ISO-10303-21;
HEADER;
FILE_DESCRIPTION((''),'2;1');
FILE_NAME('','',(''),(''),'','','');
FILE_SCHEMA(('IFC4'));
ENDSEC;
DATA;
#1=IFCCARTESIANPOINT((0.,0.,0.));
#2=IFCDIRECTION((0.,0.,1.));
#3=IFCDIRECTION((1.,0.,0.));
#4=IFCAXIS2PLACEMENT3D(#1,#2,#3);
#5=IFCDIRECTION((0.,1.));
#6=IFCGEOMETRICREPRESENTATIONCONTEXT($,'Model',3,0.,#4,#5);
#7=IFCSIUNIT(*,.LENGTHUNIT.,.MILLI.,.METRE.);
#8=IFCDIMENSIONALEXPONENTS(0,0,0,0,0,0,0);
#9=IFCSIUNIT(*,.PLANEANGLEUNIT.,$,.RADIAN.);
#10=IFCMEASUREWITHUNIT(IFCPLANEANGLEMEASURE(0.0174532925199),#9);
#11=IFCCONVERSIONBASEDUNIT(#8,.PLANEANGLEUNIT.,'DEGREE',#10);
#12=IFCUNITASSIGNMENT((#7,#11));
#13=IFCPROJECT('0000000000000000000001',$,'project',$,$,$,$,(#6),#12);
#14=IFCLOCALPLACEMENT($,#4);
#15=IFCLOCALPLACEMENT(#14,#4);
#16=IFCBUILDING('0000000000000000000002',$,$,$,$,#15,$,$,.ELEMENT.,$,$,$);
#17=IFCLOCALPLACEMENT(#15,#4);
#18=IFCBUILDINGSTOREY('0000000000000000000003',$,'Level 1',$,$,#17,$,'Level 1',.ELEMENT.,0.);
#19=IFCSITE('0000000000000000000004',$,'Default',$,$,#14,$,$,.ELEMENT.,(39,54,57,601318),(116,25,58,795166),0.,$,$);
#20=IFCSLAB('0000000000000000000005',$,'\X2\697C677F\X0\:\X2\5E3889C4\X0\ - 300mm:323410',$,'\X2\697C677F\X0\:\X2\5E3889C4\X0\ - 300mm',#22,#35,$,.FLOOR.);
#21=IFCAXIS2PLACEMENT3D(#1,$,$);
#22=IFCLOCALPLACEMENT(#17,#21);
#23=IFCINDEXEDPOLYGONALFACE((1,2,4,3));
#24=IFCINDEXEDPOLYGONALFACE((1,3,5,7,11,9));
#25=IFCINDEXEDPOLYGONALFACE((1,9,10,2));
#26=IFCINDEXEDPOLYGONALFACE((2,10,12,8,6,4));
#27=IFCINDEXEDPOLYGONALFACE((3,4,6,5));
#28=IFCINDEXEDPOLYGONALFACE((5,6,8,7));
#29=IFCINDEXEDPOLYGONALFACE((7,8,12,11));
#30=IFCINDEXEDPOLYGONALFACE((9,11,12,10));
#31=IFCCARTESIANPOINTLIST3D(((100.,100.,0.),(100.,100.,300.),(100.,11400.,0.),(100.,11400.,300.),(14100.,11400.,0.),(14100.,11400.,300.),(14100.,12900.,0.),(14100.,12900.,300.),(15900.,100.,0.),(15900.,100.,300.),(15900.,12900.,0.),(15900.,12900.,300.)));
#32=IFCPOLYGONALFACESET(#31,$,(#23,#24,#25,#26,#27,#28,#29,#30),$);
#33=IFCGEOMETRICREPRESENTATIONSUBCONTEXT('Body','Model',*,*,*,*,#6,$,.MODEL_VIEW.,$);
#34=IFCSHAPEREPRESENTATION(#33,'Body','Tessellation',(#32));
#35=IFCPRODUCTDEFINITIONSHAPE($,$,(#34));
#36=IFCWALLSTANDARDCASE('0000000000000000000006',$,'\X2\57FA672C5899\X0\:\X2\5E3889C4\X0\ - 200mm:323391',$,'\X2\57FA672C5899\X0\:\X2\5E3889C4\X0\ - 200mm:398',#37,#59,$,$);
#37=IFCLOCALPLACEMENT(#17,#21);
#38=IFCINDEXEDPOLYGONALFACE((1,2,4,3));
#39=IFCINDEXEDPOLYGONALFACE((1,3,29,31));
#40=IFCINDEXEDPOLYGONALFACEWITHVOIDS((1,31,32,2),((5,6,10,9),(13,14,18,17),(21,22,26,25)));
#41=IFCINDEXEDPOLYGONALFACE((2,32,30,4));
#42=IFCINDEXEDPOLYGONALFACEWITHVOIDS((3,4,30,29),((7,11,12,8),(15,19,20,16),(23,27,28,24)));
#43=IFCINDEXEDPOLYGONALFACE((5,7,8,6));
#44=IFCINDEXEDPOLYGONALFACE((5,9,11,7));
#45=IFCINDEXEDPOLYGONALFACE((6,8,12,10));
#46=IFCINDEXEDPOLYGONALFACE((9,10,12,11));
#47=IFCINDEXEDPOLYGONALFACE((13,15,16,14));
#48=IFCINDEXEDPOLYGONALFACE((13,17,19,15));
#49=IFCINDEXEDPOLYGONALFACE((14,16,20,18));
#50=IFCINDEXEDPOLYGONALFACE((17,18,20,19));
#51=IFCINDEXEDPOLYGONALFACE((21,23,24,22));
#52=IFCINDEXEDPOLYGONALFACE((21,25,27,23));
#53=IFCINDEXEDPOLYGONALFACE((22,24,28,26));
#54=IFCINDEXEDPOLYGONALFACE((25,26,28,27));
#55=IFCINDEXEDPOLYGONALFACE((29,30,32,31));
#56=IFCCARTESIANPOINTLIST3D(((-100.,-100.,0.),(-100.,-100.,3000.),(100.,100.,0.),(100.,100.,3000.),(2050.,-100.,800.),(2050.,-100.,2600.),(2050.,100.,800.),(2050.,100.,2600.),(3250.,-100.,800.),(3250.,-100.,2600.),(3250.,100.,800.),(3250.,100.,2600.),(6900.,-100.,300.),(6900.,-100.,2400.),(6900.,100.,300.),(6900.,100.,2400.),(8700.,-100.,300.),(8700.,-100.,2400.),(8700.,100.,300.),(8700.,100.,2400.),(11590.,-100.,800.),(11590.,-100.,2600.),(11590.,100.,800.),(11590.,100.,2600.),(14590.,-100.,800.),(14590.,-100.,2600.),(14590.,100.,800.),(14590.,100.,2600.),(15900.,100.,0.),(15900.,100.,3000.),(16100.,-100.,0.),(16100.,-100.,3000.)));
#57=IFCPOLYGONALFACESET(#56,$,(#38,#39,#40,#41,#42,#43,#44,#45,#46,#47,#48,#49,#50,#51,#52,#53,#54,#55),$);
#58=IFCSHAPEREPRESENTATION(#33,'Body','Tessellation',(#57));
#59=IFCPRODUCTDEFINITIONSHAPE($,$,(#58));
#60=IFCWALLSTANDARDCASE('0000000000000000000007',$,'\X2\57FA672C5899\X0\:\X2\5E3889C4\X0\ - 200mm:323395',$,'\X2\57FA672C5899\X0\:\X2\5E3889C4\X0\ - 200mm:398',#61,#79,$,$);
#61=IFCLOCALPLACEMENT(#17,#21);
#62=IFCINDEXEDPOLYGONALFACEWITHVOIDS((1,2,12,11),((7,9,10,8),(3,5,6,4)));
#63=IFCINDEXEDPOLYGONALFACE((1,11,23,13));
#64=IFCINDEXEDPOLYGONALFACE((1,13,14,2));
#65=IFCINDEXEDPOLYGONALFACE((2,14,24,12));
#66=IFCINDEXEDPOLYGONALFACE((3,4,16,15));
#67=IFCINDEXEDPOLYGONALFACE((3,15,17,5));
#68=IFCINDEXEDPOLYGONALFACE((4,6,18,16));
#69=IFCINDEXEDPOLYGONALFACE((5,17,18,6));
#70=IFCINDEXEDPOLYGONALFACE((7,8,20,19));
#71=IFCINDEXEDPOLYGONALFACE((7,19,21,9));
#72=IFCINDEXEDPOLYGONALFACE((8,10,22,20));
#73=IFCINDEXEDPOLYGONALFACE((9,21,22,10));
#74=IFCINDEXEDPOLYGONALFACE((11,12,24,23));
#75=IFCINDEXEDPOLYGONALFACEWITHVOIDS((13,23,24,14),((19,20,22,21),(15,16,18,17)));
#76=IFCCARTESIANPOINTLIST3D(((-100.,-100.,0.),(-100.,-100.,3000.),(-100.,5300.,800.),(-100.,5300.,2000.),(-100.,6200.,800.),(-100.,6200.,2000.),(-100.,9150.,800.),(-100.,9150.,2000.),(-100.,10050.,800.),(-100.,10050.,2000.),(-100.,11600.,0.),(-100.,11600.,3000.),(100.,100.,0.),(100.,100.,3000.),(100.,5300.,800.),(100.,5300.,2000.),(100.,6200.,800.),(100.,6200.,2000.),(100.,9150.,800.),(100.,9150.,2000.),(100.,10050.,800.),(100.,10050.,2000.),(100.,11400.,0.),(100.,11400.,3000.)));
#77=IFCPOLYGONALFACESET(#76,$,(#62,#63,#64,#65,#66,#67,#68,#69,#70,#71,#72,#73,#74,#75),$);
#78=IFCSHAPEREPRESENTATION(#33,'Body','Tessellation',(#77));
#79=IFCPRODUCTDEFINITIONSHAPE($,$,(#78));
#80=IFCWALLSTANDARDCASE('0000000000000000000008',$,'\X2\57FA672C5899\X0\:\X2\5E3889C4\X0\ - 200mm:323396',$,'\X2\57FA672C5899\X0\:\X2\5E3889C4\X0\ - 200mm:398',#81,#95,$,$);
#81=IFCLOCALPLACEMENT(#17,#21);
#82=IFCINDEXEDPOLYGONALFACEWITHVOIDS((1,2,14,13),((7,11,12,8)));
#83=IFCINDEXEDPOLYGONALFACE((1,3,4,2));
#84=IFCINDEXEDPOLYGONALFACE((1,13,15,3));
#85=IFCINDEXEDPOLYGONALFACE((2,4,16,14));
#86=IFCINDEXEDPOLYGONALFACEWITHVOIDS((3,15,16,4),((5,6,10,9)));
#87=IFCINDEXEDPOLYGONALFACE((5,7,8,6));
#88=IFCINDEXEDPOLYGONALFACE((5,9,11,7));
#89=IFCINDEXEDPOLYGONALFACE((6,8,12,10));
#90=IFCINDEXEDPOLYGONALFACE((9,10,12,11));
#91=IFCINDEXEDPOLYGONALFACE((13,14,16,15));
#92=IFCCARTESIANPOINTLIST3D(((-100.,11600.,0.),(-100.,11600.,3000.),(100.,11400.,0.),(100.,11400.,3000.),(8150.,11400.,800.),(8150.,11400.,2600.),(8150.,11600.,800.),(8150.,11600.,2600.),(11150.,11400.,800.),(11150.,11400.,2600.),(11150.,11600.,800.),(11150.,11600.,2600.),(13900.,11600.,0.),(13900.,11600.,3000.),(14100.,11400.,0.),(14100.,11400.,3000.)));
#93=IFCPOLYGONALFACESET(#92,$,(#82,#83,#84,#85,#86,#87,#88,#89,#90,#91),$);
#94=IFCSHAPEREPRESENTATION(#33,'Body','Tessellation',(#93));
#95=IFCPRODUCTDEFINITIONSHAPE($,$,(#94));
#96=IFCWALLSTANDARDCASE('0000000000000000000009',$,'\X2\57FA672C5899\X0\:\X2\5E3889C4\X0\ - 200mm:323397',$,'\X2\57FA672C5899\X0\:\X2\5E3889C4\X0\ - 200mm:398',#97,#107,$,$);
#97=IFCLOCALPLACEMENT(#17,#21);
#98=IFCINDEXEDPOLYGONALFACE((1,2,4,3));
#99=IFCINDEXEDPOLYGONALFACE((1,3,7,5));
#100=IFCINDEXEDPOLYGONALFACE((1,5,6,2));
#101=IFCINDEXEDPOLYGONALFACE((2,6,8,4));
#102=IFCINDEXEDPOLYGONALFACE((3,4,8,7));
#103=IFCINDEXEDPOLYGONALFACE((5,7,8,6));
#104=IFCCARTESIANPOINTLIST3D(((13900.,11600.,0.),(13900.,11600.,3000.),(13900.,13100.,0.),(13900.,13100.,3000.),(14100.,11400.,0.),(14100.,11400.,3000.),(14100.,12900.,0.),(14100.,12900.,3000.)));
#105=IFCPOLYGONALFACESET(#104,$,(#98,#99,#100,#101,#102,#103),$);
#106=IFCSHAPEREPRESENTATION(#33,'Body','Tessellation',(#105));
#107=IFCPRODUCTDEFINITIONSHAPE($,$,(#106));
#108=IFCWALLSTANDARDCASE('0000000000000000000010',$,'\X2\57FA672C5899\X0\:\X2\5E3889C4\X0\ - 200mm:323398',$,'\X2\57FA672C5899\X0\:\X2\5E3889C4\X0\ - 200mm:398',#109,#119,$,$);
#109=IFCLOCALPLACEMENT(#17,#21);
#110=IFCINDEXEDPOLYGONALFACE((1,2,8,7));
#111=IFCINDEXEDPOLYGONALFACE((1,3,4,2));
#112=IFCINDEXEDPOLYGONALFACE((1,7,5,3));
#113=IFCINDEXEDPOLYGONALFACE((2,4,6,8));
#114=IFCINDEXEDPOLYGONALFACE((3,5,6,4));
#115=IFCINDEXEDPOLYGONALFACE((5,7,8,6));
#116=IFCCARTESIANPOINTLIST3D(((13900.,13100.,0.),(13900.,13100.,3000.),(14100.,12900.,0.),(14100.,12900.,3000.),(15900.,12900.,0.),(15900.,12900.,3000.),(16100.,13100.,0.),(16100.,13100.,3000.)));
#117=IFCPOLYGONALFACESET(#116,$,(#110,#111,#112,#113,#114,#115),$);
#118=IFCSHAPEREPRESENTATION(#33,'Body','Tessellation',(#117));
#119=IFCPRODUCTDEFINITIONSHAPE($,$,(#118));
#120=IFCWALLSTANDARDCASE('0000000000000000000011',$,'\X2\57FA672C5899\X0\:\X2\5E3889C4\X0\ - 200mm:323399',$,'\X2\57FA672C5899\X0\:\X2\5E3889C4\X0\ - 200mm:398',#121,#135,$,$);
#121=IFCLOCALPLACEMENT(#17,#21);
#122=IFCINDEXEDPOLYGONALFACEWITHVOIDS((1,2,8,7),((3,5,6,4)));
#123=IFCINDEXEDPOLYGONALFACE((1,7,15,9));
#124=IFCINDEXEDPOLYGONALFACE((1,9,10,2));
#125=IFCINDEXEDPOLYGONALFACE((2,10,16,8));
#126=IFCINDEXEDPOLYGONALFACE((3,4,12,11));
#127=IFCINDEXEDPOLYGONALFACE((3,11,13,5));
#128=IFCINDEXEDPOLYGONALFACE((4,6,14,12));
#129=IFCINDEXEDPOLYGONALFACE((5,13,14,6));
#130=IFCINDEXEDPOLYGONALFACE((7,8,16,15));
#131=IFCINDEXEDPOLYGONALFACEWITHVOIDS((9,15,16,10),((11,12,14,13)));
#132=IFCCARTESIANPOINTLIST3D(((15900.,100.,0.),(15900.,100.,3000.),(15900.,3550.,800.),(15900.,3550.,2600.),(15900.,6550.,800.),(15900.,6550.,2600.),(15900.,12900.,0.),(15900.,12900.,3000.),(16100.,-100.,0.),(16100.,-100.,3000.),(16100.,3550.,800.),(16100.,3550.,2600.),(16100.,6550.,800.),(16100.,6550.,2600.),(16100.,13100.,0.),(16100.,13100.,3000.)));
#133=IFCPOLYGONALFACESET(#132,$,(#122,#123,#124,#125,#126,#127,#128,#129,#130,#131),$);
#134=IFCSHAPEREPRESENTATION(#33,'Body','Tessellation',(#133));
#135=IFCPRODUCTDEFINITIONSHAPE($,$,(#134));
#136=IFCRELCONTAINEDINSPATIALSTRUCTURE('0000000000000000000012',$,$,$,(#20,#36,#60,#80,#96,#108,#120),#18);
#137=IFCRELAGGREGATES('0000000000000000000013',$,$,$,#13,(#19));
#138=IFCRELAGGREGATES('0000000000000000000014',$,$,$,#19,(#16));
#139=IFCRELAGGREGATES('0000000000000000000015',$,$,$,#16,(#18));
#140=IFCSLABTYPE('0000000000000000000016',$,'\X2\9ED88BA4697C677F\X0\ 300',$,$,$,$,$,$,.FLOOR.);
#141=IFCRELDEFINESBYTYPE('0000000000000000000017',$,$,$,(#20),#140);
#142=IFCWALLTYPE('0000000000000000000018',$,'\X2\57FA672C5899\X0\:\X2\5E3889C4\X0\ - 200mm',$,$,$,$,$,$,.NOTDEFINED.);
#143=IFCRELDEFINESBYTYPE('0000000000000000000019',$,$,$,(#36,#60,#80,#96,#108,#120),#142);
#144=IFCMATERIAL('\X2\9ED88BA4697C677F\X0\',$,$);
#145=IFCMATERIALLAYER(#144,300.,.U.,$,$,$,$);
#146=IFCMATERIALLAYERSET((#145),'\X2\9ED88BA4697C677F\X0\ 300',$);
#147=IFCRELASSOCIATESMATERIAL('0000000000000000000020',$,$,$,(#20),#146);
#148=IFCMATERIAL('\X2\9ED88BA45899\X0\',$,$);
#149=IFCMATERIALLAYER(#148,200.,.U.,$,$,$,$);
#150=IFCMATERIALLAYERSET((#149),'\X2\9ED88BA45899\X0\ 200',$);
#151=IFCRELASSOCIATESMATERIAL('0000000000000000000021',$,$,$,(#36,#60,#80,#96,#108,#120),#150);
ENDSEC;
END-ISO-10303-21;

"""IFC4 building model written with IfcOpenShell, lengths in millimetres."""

from ifc_helpers import new_model, entity, si_unit, converted_unit, direction, frame, origin_with_axes, place, context, subcontext, project, spatial, polyline, outline, extrude, material, layer, layer_set, layer_usage, type_object, element, save


model = new_model("IFC4")

# Units and contexts
model_context = context("Model", 3, precision=0.0, world=origin_with_axes(), true_north=direction((0.0, 1.0)))
body_context = subcontext(model_context, "Body", "Model", "MODEL_VIEW")
ifc_project = project(units=[si_unit("LENGTHUNIT", "METRE", prefix="MILLI"), converted_unit("PLANEANGLEUNIT", "DEGREE", entity("IfcPlaneAngleMeasure", 0.0174532925199), si_unit("PLANEANGLEUNIT", "RADIAN"), dimensions=[0, 0, 0, 0, 0, 0, 0])], contexts=[model_context])

# Site, building, storey
site_placement = place(None, origin_with_axes())
site = spatial("IfcSite", under=ifc_project, at=site_placement, Name="Default", CompositionType="ELEMENT", RefLatitude=(39, 54, 57, 601318), RefLongitude=(116, 25, 58, 795166), RefElevation=0.0)
building_placement = place(site_placement, origin_with_axes())
building = spatial("IfcBuilding", under=site, at=building_placement, CompositionType="ELEMENT")
storey_placement = place(building_placement, origin_with_axes())
storey = spatial("IfcBuildingStorey", under=building, at=storey_placement, Name="Level 1", LongName="Level 1", CompositionType="ELEMENT", Elevation=0.0)

# Slab
ifc_material_1 = material(Name="默认楼板")
ifc_layer_1 = layer(ifc_material_1, 300.0, ventilated="UNKNOWN")
ifc_layer_set_1 = layer_set([ifc_layer_1], Name="默认楼板 300")
ifc_layer_usage_1 = layer_usage(ifc_layer_set_1, "AXIS3", "NEGATIVE", 300.0)
slab_type = type_object("IfcSlabType", Name="默认楼板 300", PredefinedType="FLOOR")
slab_placement = place(storey_placement, frame((100.0, 100.0, 0.0), z_axis=(0.0, 0.0, 1.0), x_axis=(1.0, 0.0, 0.0)))
element("IfcSlab", 1, at=slab_placement, inside=storey, type_object=slab_type, material=ifc_layer_usage_1, Name="楼板:常规 - 300mm:323410", ObjectType="楼板:常规 - 300mm", PredefinedType="FLOOR", context=body_context, shape_type="SweptSolid", body=[
    extrude(outline(polyline([(0.0, 0.0), (15800.0, 0.0), (15800.0, 12800.0), (14000.0, 12800.0), (14000.0, 11300.0), (0.0, 11300.0), (0.0, 0.0)])), origin_with_axes(), (0.0, 0.0, 1.0), 300.0),
])

# Walls, openings
ifc_material_2 = material(Name="默认墙")
ifc_layer_2 = layer(ifc_material_2, 200.0, ventilated="UNKNOWN")
ifc_layer_set_2 = layer_set([ifc_layer_2], Name="默认墙 200")
ifc_layer_usage_2 = layer_usage(ifc_layer_set_2, "AXIS2", "POSITIVE", -100.0)
wall_type = type_object("IfcWallType", Name="基本墙:常规 - 200mm", PredefinedType="NOTDEFINED")
wall_1_placement = place(storey_placement, frame((16000.0, 0.0, 0.0), z_axis=(0.0, 0.0, 1.0), x_axis=(-1.0, 0.0, 0.0)))
wall_1 = element("IfcWallStandardCase", 2, at=wall_1_placement, inside=storey, type_object=wall_type, material=ifc_layer_usage_2, Name="基本墙:常规 - 200mm:323391", ObjectType="基本墙:常规 - 200mm:398", context=body_context, shape_type="SweptSolid", body=[
    extrude(outline(polyline([(100.0, -100.0), (15900.0, -100.0), (16100.0, 100.0), (-100.0, 100.0), (100.0, -100.0)])), origin_with_axes(), (0.0, 0.0, 1.0), 3000.0),
])
opening_1_placement = place(wall_1_placement, frame((13350.0, 0.0, 800.0), z_axis=(0.0, 0.0, 1.0), x_axis=(1.0, 0.0, 0.0)))
element("IfcOpeningElement", 3, at=opening_1_placement, cuts=wall_1, context=body_context, shape_type="SweptSolid", body=[
    extrude(outline(polyline([(-600.0, 0.0), (-600.0, -1800.0), (600.0, -1800.0), (600.0, 0.0), (-600.0, 0.0)])), frame((0.0, -100.0, 0.0), z_axis=(0.0, 1.0, 0.0), x_axis=(1.0, 0.0, 0.0)), (0.0, 0.0, 1.0), 200.0),
])
opening_2_placement = place(wall_1_placement, frame((2910.0, 0.0, 800.0), z_axis=(0.0, 0.0, 1.0), x_axis=(1.0, 0.0, 0.0)))
element("IfcOpeningElement", 4, at=opening_2_placement, cuts=wall_1, context=body_context, shape_type="SweptSolid", body=[
    extrude(outline(polyline([(-1500.0, 0.0), (-1500.0, -1800.0), (1500.0, -1800.0), (1500.0, 0.0), (-1500.0, 0.0)])), frame((0.0, -100.0, 0.0), z_axis=(0.0, 1.0, 0.0), x_axis=(1.0, 0.0, 0.0)), (0.0, 0.0, 1.0), 200.0),
])
opening_3_placement = place(wall_1_placement, frame((8200.0, 0.0, 300.0), z_axis=(0.0, 0.0, 1.0), x_axis=(1.0, 0.0, 0.0)))
element("IfcOpeningElement", 5, at=opening_3_placement, cuts=wall_1, context=body_context, shape_type="SweptSolid", body=[
    extrude(outline(polyline([(-900.0, 0.0), (-900.0, -2100.0), (900.0, -2100.0), (900.0, 0.0), (-900.0, 0.0)])), frame((0.0, -100.0, 0.0), z_axis=(0.0, 1.0, 0.0), x_axis=(1.0, 0.0, 0.0)), (0.0, 0.0, 1.0), 200.0),
])
ifc_layer_usage_3 = layer_usage(ifc_layer_set_2, "AXIS2", "POSITIVE", -100.0)
wall_2_placement = place(storey_placement, frame((0.0, 0.0, 0.0), z_axis=(0.0, 0.0, 1.0), x_axis=(0.0, 1.0, 0.0)))
wall_2 = element("IfcWallStandardCase", 6, at=wall_2_placement, inside=storey, type_object=wall_type, material=ifc_layer_usage_3, Name="基本墙:常规 - 200mm:323395", ObjectType="基本墙:常规 - 200mm:398", context=body_context, shape_type="SweptSolid", body=[
    extrude(outline(polyline([(100.0, -100.0), (11400.0, -100.0), (11600.0, 100.0), (-100.0, 100.0), (100.0, -100.0)])), origin_with_axes(), (0.0, 0.0, 1.0), 3000.0),
])
opening_4_placement = place(wall_2_placement, frame((5750.0, 0.0, 800.0), z_axis=(0.0, 0.0, 1.0), x_axis=(1.0, 0.0, 0.0)))
element("IfcOpeningElement", 7, at=opening_4_placement, cuts=wall_2, context=body_context, shape_type="SweptSolid", body=[
    extrude(outline(polyline([(450.0, -1200.0), (450.0, 0.0), (-450.0, 0.0), (-450.0, -1200.0), (450.0, -1200.0)])), frame((0.0, 100.0, 0.0), z_axis=(0.0, -1.0, 0.0), x_axis=(-1.0, 0.0, 0.0)), (0.0, 0.0, 1.0), 200.0),
])
opening_5_placement = place(wall_2_placement, frame((9600.0, 0.0, 800.0), z_axis=(0.0, 0.0, 1.0), x_axis=(1.0, 0.0, 0.0)))
element("IfcOpeningElement", 8, at=opening_5_placement, cuts=wall_2, context=body_context, shape_type="SweptSolid", body=[
    extrude(outline(polyline([(450.0, -1200.0), (450.0, 0.0), (-450.0, 0.0), (-450.0, -1200.0), (450.0, -1200.0)])), frame((0.0, 100.0, 0.0), z_axis=(0.0, -1.0, 0.0), x_axis=(-1.0, 0.0, 0.0)), (0.0, 0.0, 1.0), 200.0),
])

# Wall, opening
ifc_layer_usage_4 = layer_usage(ifc_layer_set_2, "AXIS2", "POSITIVE", -100.0)
wall_3_placement = place(storey_placement, frame((0.0, 11500.0, 0.0), z_axis=(0.0, 0.0, 1.0), x_axis=(1.0, 0.0, 0.0)))
wall_3 = element("IfcWallStandardCase", 9, at=wall_3_placement, inside=storey, type_object=wall_type, material=ifc_layer_usage_4, Name="基本墙:常规 - 200mm:323396", ObjectType="基本墙:常规 - 200mm:398", context=body_context, shape_type="SweptSolid", body=[
    extrude(outline(polyline([(100.0, -100.0), (14100.0, -100.0), (13900.0, 100.0), (-100.0, 100.0), (100.0, -100.0)])), origin_with_axes(), (0.0, 0.0, 1.0), 3000.0),
])
opening_6_placement = place(wall_3_placement, frame((9650.0, 0.0, 800.0), z_axis=(0.0, 0.0, 1.0), x_axis=(1.0, 0.0, 0.0)))
element("IfcOpeningElement", 10, at=opening_6_placement, cuts=wall_3, context=body_context, shape_type="SweptSolid", body=[
    extrude(outline(polyline([(-1500.0, 0.0), (-1500.0, -1800.0), (1500.0, -1800.0), (1500.0, 0.0), (-1500.0, 0.0)])), frame((0.0, -100.0, 0.0), z_axis=(0.0, 1.0, 0.0), x_axis=(1.0, 0.0, 0.0)), (0.0, 0.0, 1.0), 200.0),
])

# Walls
ifc_layer_usage_5 = layer_usage(ifc_layer_set_2, "AXIS2", "POSITIVE", -100.0)
wall_4_placement = place(storey_placement, frame((14000.0, 11500.0, 0.0), z_axis=(0.0, 0.0, 1.0), x_axis=(0.0, 1.0, 0.0)))
element("IfcWallStandardCase", 11, at=wall_4_placement, inside=storey, type_object=wall_type, material=ifc_layer_usage_5, Name="基本墙:常规 - 200mm:323397", ObjectType="基本墙:常规 - 200mm:398", context=body_context, shape_type="SweptSolid", body=[
    extrude(outline(polyline([(-100.0, -100.0), (1400.0, -100.0), (1600.0, 100.0), (100.0, 100.0), (-100.0, -100.0)])), origin_with_axes(), (0.0, 0.0, 1.0), 3000.0),
])
ifc_layer_usage_6 = layer_usage(ifc_layer_set_2, "AXIS2", "POSITIVE", -100.0)
wall_5_placement = place(storey_placement, frame((14000.0, 13000.0, 0.0), z_axis=(0.0, 0.0, 1.0), x_axis=(1.0, 0.0, 0.0)))
element("IfcWallStandardCase", 12, at=wall_5_placement, inside=storey, type_object=wall_type, material=ifc_layer_usage_6, Name="基本墙:常规 - 200mm:323398", ObjectType="基本墙:常规 - 200mm:398", context=body_context, shape_type="SweptSolid", body=[
    extrude(outline(polyline([(100.0, -100.0), (1900.0, -100.0), (2100.0, 100.0), (-100.0, 100.0), (100.0, -100.0)])), origin_with_axes(), (0.0, 0.0, 1.0), 3000.0),
])

# Wall, opening
ifc_layer_usage_7 = layer_usage(ifc_layer_set_2, "AXIS2", "POSITIVE", -100.0)
wall_6_placement = place(storey_placement, frame((16000.0, 13000.0, 0.0), z_axis=(0.0, 0.0, 1.0), x_axis=(0.0, -1.0, 0.0)))
wall_6 = element("IfcWallStandardCase", 13, at=wall_6_placement, inside=storey, type_object=wall_type, material=ifc_layer_usage_7, Name="基本墙:常规 - 200mm:323399", ObjectType="基本墙:常规 - 200mm:398", context=body_context, shape_type="SweptSolid", body=[
    extrude(outline(polyline([(100.0, -100.0), (12900.0, -100.0), (13100.0, 100.0), (-100.0, 100.0), (100.0, -100.0)])), origin_with_axes(), (0.0, 0.0, 1.0), 3000.0),
])
opening_7_placement = place(wall_6_placement, frame((7950.0, 0.0, 800.0), z_axis=(0.0, 0.0, 1.0), x_axis=(1.0, 0.0, 0.0)))
element("IfcOpeningElement", 14, at=opening_7_placement, cuts=wall_6, context=body_context, shape_type="SweptSolid", body=[
    extrude(outline(polyline([(-1500.0, 0.0), (-1500.0, -1800.0), (1500.0, -1800.0), (1500.0, 0.0), (-1500.0, 0.0)])), frame((0.0, -100.0, 0.0), z_axis=(0.0, 1.0, 0.0), x_axis=(1.0, 0.0, 0.0)), (0.0, 0.0, 1.0), 200.0),
])

save(model, "model.ifc")
